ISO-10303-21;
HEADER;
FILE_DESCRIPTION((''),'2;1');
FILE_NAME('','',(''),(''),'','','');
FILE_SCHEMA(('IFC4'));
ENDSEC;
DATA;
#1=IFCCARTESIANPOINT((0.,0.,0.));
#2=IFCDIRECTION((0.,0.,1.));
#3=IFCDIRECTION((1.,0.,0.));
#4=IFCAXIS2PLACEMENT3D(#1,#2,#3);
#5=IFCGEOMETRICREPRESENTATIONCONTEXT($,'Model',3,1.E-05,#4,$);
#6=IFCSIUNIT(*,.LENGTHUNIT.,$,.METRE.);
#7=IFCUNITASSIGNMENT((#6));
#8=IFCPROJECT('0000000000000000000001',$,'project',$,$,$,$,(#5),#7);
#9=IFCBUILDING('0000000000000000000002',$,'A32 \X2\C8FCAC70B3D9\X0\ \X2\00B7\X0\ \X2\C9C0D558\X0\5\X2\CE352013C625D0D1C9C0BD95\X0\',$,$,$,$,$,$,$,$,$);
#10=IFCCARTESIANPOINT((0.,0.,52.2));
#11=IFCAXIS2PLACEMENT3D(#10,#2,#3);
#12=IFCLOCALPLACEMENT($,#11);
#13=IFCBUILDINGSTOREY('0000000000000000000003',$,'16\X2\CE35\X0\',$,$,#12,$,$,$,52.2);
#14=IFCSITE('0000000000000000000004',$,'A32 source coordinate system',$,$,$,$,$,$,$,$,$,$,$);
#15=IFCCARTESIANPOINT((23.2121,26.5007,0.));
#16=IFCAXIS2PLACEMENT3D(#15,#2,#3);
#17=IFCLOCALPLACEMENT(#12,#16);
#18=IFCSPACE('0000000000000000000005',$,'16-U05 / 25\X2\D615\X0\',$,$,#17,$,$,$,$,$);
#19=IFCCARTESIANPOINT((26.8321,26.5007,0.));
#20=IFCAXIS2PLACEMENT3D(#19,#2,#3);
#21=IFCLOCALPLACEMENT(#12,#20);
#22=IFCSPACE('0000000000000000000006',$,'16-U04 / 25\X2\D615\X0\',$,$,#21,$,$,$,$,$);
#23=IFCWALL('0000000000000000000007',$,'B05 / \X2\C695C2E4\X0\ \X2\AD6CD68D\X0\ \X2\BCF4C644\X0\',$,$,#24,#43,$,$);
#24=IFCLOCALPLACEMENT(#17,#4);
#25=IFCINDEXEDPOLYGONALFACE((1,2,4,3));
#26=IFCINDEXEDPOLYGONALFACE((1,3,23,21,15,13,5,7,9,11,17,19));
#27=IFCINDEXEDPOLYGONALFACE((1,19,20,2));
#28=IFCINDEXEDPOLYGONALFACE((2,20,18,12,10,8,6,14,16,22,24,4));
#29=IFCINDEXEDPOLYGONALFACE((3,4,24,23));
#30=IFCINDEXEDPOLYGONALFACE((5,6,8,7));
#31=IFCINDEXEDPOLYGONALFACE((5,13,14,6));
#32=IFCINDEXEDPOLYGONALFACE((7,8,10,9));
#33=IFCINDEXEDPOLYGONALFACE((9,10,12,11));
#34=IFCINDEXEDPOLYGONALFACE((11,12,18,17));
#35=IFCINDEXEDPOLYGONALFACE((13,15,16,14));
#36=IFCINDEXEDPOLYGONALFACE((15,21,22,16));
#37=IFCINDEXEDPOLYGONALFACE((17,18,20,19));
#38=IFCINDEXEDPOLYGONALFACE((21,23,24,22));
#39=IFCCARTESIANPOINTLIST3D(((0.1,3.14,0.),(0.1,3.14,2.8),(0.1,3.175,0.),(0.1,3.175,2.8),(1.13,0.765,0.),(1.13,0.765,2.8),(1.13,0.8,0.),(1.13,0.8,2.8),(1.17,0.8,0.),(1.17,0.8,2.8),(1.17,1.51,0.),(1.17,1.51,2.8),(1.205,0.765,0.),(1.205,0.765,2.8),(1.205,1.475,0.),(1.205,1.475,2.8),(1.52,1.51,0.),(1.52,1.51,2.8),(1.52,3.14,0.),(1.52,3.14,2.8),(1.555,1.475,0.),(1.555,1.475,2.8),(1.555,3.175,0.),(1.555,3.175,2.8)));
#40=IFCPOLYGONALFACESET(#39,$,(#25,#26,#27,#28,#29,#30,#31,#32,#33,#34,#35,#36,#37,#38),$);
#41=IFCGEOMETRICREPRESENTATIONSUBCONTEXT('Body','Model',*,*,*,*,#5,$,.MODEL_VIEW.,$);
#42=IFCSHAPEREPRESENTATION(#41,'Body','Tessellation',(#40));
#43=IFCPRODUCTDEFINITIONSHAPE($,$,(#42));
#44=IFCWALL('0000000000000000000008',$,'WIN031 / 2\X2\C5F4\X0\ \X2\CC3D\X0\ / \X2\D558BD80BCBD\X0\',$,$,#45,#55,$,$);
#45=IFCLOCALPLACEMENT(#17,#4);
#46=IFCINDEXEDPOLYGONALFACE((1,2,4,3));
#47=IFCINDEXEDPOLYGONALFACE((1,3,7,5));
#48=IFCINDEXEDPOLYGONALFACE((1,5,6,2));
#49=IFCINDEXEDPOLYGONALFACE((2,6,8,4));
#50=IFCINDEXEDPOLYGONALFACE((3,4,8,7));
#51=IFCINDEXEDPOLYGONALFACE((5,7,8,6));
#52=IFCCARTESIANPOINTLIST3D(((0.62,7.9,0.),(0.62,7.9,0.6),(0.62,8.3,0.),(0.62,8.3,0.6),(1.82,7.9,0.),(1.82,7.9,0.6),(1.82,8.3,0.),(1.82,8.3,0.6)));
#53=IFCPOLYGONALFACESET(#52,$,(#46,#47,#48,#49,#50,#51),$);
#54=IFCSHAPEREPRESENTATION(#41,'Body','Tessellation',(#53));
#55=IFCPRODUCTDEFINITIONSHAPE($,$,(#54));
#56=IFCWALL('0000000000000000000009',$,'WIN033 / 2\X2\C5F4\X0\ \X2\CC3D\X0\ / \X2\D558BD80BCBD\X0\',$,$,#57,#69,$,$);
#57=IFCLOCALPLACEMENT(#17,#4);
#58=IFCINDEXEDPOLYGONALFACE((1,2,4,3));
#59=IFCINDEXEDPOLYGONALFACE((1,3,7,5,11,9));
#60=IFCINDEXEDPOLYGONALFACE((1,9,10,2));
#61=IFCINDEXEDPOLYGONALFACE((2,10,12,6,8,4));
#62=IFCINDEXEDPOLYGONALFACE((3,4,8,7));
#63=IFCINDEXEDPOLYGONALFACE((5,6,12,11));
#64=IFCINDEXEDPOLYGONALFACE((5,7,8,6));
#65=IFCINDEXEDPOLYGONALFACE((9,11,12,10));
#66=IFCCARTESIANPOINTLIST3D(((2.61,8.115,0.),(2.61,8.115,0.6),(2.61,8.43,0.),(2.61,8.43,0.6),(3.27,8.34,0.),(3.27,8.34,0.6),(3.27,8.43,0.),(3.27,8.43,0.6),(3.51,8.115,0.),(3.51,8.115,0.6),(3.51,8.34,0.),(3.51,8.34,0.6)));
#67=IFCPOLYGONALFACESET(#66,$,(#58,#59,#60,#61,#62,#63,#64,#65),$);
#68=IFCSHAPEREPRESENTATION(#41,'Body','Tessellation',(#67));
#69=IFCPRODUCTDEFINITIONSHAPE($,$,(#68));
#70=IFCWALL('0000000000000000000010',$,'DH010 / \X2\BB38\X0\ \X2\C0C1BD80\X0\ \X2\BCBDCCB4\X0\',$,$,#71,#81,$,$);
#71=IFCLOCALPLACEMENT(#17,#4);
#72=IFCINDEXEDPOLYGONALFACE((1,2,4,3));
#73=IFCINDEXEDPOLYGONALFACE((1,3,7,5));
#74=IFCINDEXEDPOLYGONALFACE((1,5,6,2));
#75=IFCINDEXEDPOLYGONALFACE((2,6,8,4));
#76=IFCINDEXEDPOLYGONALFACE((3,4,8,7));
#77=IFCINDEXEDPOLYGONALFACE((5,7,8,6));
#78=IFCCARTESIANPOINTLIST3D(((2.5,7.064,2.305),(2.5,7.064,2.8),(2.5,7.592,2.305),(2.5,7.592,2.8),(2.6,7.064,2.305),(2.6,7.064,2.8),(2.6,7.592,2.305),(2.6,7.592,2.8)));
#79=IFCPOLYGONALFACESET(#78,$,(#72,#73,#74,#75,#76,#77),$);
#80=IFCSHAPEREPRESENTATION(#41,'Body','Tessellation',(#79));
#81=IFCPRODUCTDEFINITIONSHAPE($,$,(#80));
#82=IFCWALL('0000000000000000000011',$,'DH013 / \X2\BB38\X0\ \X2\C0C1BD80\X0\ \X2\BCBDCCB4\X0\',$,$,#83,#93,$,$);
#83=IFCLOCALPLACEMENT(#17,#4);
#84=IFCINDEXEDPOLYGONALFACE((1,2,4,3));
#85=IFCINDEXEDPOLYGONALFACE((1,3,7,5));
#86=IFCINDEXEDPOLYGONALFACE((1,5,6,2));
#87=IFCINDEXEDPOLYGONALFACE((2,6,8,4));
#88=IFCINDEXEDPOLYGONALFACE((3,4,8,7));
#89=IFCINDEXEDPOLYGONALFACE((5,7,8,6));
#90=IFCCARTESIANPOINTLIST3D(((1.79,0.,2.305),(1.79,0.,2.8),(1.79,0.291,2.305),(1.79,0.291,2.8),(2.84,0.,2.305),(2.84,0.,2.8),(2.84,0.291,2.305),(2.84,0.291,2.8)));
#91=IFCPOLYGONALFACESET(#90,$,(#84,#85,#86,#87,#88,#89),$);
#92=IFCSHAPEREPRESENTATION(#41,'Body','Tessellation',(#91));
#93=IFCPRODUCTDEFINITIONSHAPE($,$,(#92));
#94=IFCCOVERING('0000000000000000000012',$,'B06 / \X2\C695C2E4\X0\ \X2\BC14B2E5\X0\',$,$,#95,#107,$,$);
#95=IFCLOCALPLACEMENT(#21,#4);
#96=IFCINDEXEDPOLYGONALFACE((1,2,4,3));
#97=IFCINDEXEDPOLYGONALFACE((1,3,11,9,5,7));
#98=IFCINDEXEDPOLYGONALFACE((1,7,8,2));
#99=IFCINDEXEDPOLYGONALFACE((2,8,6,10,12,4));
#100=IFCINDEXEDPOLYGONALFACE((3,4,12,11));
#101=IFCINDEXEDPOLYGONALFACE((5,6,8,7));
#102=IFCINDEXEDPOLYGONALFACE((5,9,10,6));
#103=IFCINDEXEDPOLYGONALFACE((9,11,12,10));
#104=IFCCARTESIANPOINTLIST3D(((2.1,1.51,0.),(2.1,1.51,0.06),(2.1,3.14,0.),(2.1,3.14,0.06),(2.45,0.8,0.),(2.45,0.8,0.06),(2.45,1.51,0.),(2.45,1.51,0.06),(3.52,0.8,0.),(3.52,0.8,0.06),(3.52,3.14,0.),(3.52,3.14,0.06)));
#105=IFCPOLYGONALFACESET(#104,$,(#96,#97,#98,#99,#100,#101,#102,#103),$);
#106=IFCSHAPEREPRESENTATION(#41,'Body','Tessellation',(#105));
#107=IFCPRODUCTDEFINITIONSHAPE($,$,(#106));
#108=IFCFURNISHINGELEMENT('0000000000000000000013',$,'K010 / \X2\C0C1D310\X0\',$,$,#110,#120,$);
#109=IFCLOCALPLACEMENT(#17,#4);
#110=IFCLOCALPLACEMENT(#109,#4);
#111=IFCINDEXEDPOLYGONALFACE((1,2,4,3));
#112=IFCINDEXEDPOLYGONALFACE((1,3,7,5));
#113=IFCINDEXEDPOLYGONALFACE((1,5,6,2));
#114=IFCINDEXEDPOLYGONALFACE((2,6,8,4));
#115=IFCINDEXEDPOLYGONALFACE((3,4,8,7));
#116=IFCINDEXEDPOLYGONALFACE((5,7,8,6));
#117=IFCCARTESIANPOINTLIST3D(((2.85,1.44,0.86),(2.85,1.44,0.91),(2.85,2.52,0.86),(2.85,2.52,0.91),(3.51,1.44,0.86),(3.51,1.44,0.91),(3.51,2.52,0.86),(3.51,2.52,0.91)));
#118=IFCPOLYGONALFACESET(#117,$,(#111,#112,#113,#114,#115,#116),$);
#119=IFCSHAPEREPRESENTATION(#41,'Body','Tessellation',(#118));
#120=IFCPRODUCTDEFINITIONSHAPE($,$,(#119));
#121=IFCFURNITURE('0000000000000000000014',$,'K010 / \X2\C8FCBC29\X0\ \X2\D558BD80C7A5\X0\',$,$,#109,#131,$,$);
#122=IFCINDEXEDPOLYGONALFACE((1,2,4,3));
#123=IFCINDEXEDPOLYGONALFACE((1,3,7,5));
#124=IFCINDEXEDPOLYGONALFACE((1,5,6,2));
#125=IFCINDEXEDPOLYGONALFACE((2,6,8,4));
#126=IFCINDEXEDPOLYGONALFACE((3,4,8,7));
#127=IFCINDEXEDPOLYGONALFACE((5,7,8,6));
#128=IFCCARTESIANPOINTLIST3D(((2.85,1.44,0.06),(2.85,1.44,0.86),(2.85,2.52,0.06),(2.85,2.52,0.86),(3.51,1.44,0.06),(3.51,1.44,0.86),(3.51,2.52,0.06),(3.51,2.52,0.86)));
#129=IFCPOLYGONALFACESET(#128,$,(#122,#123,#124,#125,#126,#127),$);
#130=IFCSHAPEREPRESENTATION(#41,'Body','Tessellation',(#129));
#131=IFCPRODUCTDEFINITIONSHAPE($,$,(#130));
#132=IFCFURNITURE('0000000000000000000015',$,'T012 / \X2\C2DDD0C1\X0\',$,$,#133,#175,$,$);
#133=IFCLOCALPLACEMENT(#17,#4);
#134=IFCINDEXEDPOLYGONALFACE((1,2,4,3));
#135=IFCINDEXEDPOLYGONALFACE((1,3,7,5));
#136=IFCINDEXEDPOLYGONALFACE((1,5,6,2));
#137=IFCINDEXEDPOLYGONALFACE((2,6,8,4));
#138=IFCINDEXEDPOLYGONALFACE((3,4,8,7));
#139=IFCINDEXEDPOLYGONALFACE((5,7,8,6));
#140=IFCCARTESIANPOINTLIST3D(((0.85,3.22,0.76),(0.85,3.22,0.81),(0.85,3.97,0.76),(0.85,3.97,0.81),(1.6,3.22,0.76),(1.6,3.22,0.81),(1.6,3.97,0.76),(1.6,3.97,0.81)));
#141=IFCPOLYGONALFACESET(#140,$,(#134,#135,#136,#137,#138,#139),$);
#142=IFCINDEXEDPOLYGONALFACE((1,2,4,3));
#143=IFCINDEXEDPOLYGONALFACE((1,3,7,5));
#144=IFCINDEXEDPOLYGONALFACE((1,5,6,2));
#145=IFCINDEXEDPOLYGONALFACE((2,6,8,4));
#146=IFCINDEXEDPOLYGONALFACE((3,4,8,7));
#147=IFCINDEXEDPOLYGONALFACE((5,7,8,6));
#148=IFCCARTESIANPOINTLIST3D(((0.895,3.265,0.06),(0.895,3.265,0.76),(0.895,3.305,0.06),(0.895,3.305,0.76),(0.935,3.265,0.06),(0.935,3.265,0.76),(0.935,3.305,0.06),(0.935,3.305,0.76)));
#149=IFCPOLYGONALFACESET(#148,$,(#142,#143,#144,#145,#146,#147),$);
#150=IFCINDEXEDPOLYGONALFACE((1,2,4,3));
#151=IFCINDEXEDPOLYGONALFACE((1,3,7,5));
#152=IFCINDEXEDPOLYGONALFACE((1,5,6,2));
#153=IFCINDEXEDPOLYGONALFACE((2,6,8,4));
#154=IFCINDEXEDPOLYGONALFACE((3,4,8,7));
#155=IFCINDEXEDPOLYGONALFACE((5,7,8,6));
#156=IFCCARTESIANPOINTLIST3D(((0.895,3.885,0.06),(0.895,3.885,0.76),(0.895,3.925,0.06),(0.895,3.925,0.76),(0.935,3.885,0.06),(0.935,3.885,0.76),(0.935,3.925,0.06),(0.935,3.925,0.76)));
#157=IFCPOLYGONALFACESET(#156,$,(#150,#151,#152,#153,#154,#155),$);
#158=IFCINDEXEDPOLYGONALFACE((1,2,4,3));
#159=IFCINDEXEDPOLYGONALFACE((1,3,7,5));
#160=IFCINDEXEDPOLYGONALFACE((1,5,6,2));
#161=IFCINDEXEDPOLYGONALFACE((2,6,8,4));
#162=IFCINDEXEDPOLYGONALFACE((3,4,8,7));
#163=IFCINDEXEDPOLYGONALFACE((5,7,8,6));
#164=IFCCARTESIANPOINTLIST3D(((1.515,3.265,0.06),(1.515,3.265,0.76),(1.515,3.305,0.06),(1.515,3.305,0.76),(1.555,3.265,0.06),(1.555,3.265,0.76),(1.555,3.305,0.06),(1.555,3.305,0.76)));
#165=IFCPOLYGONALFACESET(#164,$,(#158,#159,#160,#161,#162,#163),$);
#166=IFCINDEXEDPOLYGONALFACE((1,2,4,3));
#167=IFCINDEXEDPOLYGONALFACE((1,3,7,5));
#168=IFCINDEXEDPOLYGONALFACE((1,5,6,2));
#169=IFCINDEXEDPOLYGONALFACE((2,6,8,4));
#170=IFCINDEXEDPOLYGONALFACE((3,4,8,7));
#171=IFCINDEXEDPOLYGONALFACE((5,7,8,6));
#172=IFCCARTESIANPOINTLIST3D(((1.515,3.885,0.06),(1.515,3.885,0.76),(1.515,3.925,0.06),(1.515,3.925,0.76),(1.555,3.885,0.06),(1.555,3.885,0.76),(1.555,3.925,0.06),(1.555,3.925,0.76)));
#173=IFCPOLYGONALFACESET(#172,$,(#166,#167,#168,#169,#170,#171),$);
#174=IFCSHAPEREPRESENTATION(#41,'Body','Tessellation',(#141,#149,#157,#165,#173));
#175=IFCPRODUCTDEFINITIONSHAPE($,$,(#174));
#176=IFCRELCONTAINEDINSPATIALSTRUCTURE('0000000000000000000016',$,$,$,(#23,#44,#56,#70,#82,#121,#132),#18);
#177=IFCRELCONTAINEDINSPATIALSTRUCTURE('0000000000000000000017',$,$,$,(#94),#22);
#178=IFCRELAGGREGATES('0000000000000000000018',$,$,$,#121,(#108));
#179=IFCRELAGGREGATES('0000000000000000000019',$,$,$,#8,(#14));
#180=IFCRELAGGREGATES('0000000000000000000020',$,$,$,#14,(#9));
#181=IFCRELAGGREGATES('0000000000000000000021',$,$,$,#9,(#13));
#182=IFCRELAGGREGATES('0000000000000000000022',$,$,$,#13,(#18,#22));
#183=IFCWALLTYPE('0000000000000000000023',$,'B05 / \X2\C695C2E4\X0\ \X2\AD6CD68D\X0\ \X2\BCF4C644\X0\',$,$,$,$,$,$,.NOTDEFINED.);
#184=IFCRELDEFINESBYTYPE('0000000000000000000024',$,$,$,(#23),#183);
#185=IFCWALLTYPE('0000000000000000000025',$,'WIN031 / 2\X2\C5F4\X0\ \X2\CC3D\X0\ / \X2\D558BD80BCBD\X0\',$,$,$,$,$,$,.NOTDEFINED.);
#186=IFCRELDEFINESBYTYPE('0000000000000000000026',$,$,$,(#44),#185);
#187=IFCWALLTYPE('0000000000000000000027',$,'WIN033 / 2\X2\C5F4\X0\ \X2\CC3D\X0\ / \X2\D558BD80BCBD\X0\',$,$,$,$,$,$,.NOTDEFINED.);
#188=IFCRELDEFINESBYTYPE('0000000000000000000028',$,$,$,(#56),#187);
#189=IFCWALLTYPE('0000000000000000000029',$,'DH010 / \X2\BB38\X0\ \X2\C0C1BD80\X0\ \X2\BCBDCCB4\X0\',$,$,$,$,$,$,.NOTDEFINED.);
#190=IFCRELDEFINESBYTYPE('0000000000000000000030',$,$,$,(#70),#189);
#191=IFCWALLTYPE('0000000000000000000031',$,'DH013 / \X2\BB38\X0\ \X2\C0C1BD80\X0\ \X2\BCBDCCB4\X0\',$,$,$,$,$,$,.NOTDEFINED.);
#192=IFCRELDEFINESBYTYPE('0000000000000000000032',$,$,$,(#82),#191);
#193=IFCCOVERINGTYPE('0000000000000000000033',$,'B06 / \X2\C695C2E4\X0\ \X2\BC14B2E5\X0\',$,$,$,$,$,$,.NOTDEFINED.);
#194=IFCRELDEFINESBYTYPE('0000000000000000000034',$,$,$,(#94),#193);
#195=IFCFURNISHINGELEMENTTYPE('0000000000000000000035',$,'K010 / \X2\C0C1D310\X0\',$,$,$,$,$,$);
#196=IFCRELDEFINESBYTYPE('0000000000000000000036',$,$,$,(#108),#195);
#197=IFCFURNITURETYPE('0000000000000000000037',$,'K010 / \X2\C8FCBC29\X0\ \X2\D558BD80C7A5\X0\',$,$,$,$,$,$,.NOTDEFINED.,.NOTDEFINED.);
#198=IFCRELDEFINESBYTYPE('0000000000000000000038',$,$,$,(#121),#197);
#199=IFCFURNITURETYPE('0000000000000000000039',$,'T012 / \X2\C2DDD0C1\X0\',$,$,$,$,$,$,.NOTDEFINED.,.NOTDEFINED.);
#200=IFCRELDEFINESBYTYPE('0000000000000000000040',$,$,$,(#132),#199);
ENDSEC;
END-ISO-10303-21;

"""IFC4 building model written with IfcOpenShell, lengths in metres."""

from ifc_helpers import new_model, si_unit, frame, origin, origin_with_axes, place, context, subcontext, project, spatial, polyline, outline, extrude, source, transform, mapped, type_object, type_shapes, element, aggregate, save


model = new_model("IFC4")

# Units and contexts
model_context = context("Model", 3, precision=1e-05, world=origin_with_axes())
body_context = subcontext(model_context, "Body", "Model", "MODEL_VIEW")
ifc_project = project(units=[si_unit("LENGTHUNIT", "METRE")], contexts=[model_context])

# Site, building, storey, space
site = spatial("IfcSite", under=ifc_project, Name="A32 source coordinate system")
building = spatial("IfcBuilding", under=site, Name="A32 주거동 · 지하5층–옥탑지붕")
storey_placement = place(None, frame((0.0, 0.0, 52.2), z_axis=(0.0, 0.0, 1.0), x_axis=(1.0, 0.0, 0.0)))
storey = spatial("IfcBuildingStorey", under=building, at=storey_placement, Name="16층", Elevation=52.2)
space_1_placement = place(storey_placement, frame((23.2121, 26.5007, 0.0), z_axis=(0.0, 0.0, 1.0), x_axis=(1.0, 0.0, 0.0)))
space_1 = spatial("IfcSpace", under=storey, at=space_1_placement, Name="16-U05 / 25형")

# Walls
wall_type_1 = type_object("IfcWallType", Name="B05 / 욕실 구획 보완", PredefinedType="NOTDEFINED")
shared_shape_1 = source(origin(), body_context, "Body", "SweptSolid", [
    extrude(outline(polyline([(1.17, 1.51), (1.52, 1.51), (1.52, 3.14), (0.1, 3.14), (0.1, 3.175), (1.555, 3.175), (1.555, 1.475), (1.205, 1.475), (1.205, 0.765), (1.13, 0.765), (1.13, 0.8), (1.17, 0.8), (1.17, 1.51)])), origin(), (0.0, 0.0, 1.0), 2.8),
])
type_shapes(wall_type_1, [shared_shape_1])
wall_1_placement = place(space_1_placement, origin_with_axes())
element("IfcWall", 1, at=wall_1_placement, inside=space_1, type_object=wall_type_1, Name="B05 / 욕실 구획 보완", context=body_context, shape_type="MappedRepresentation", body=[
    mapped(shared_shape_1, transform((0.0, 0.0, 0.0), scale=1.0)),
])
wall_type_2 = type_object("IfcWallType", Name="WIN031 / 2열 창 / 하부벽", PredefinedType="NOTDEFINED")
shared_shape_2 = source(origin(), body_context, "Body", "SweptSolid", [
    extrude(outline(polyline([(0.62, 8.3), (1.82, 8.3), (1.82, 7.9), (0.62, 7.9), (0.62, 8.3)])), origin(), (0.0, 0.0, 1.0), 0.6),
])
type_shapes(wall_type_2, [shared_shape_2])
wall_2_placement = place(space_1_placement, origin_with_axes())
element("IfcWall", 2, at=wall_2_placement, inside=space_1, type_object=wall_type_2, Name="WIN031 / 2열 창 / 하부벽", context=body_context, shape_type="MappedRepresentation", body=[
    mapped(shared_shape_2, transform((0.0, 0.0, 0.0), scale=1.0)),
])
wall_type_3 = type_object("IfcWallType", Name="WIN033 / 2열 창 / 하부벽", PredefinedType="NOTDEFINED")
shared_shape_3 = source(origin(), body_context, "Body", "SweptSolid", [
    extrude(outline(polyline([(2.61, 8.43), (3.27, 8.43), (3.27, 8.34), (3.51, 8.34), (3.51, 8.115), (2.61, 8.115), (2.61, 8.43)])), origin(), (0.0, 0.0, 1.0), 0.6),
])
type_shapes(wall_type_3, [shared_shape_3])
wall_3_placement = place(space_1_placement, origin_with_axes())
element("IfcWall", 3, at=wall_3_placement, inside=space_1, type_object=wall_type_3, Name="WIN033 / 2열 창 / 하부벽", context=body_context, shape_type="MappedRepresentation", body=[
    mapped(shared_shape_3, transform((0.0, 0.0, 0.0), scale=1.0)),
])
wall_type_4 = type_object("IfcWallType", Name="DH010 / 문 상부 벽체", PredefinedType="NOTDEFINED")
shared_shape_4 = source(origin(), body_context, "Body", "SweptSolid", [
    extrude(outline(polyline([(2.5, 7.592), (2.6, 7.592), (2.6, 7.064), (2.5, 7.064), (2.5, 7.592)])), frame((0.0, 0.0, 2.305)), (0.0, 0.0, 1.0), 0.495),
])
type_shapes(wall_type_4, [shared_shape_4])
wall_4_placement = place(space_1_placement, origin_with_axes())
element("IfcWall", 4, at=wall_4_placement, inside=space_1, type_object=wall_type_4, Name="DH010 / 문 상부 벽체", context=body_context, shape_type="MappedRepresentation", body=[
    mapped(shared_shape_4, transform((0.0, 0.0, 0.0), scale=1.0)),
])
wall_type_5 = type_object("IfcWallType", Name="DH013 / 문 상부 벽체", PredefinedType="NOTDEFINED")
shared_shape_5 = source(origin(), body_context, "Body", "SweptSolid", [
    extrude(outline(polyline([(2.84, 0.291), (2.84, 0.0), (1.79, 0.0), (1.79, 0.291), (2.84, 0.291)])), frame((0.0, 0.0, 2.305)), (0.0, 0.0, 1.0), 0.495),
])
type_shapes(wall_type_5, [shared_shape_5])
wall_5_placement = place(space_1_placement, origin_with_axes())
element("IfcWall", 5, at=wall_5_placement, inside=space_1, type_object=wall_type_5, Name="DH013 / 문 상부 벽체", context=body_context, shape_type="MappedRepresentation", body=[
    mapped(shared_shape_5, transform((0.0, 0.0, 0.0), scale=1.0)),
])

# Shared definitions
space_2_placement = place(storey_placement, frame((26.8321, 26.5007, 0.0), z_axis=(0.0, 0.0, 1.0), x_axis=(1.0, 0.0, 0.0)))
space_2 = spatial("IfcSpace", under=storey, at=space_2_placement, Name="16-U04 / 25형")

# Covering
covering_type = type_object("IfcCoveringType", Name="B06 / 욕실 바닥", PredefinedType="NOTDEFINED")
shared_shape_6 = source(origin(), body_context, "Body", "SweptSolid", [
    extrude(outline(polyline([(2.1, 3.14), (3.52, 3.14), (3.52, 0.8), (2.45, 0.8), (2.45, 1.51), (2.1, 1.51), (2.1, 3.14)])), origin(), (0.0, 0.0, 1.0), 0.06),
])
type_shapes(covering_type, [shared_shape_6])
covering_placement = place(space_2_placement, origin_with_axes())
element("IfcCovering", 6, at=covering_placement, inside=space_2, type_object=covering_type, Name="B06 / 욕실 바닥", context=body_context, shape_type="MappedRepresentation", body=[
    mapped(shared_shape_6, transform((0.0, 0.0, 0.0), scale=1.0)),
])

# Furnishing element
furnishing_element_type_1 = type_object("IfcFurnishingElementType", Name="K010 / 상판")
shared_shape_7 = source(origin(), body_context, "Body", "SweptSolid", [
    extrude(outline(polyline([(2.85, 2.52), (3.51, 2.52), (3.51, 1.44), (2.85, 1.44), (2.85, 2.52)])), frame((0.0, 0.0, 0.86)), (0.0, 0.0, 1.0), 0.05),
])
type_shapes(furnishing_element_type_1, [shared_shape_7])
furniture_1_placement = place(space_1_placement, origin_with_axes())
furnishing_1_placement = place(furniture_1_placement, origin_with_axes())
furnishing_1 = element("IfcFurnishingElement", 7, at=furnishing_1_placement, type_object=furnishing_element_type_1, Name="K010 / 상판", context=body_context, shape_type="MappedRepresentation", body=[
    mapped(shared_shape_7, transform((0.0, 0.0, 0.0), scale=1.0)),
])

# Furniture
furniture_type_1 = type_object("IfcFurnitureType", Name="K010 / 주방 하부장", AssemblyPlace="NOTDEFINED", PredefinedType="NOTDEFINED")
shared_shape_8 = source(origin(), body_context, "Body", "SweptSolid", [
    extrude(outline(polyline([(2.85, 1.44), (2.85, 2.52), (3.51, 2.52), (3.51, 1.44), (2.85, 1.44)])), frame((0.0, 0.0, 0.06)), (0.0, 0.0, 1.0), 0.8),
])
type_shapes(furniture_type_1, [shared_shape_8])
furniture_1 = element("IfcFurniture", 8, at=furniture_1_placement, inside=space_1, type_object=furniture_type_1, Name="K010 / 주방 하부장", context=body_context, shape_type="MappedRepresentation", body=[
    mapped(shared_shape_8, transform((0.0, 0.0, 0.0), scale=1.0)),
])
aggregate(furniture_1, [furnishing_1])
furniture_type_2 = type_object("IfcFurnitureType", Name="T012 / 식탁", AssemblyPlace="NOTDEFINED", PredefinedType="NOTDEFINED")
shared_shape_9 = source(origin(), body_context, "Body", "SweptSolid", [
    extrude(outline(polyline([(1.6, 3.97), (1.6, 3.22), (0.85, 3.22), (0.85, 3.97), (1.6, 3.97)])), frame((0.0, 0.0, 0.76)), (0.0, 0.0, 1.0), 0.05),
    extrude(outline(polyline([(0.895, 3.265), (0.895, 3.305), (0.935, 3.305), (0.935, 3.265), (0.895, 3.265)])), frame((0.0, 0.0, 0.06)), (0.0, 0.0, 1.0), 0.7),
    extrude(outline(polyline([(0.895, 3.885), (0.895, 3.925), (0.935, 3.925), (0.935, 3.885), (0.895, 3.885)])), frame((0.0, 0.0, 0.06)), (0.0, 0.0, 1.0), 0.7),
    extrude(outline(polyline([(1.515, 3.265), (1.515, 3.305), (1.555, 3.305), (1.555, 3.265), (1.515, 3.265)])), frame((0.0, 0.0, 0.06)), (0.0, 0.0, 1.0), 0.7),
    extrude(outline(polyline([(1.515, 3.885), (1.515, 3.925), (1.555, 3.925), (1.555, 3.885), (1.515, 3.885)])), frame((0.0, 0.0, 0.06)), (0.0, 0.0, 1.0), 0.7),
])
type_shapes(furniture_type_2, [shared_shape_9])
furniture_2_placement = place(space_1_placement, origin_with_axes())
element("IfcFurniture", 9, at=furniture_2_placement, inside=space_1, type_object=furniture_type_2, Name="T012 / 식탁", context=body_context, shape_type="MappedRepresentation", body=[
    mapped(shared_shape_9, transform((0.0, 0.0, 0.0), scale=1.0)),
])

save(model, "model.ifc")
